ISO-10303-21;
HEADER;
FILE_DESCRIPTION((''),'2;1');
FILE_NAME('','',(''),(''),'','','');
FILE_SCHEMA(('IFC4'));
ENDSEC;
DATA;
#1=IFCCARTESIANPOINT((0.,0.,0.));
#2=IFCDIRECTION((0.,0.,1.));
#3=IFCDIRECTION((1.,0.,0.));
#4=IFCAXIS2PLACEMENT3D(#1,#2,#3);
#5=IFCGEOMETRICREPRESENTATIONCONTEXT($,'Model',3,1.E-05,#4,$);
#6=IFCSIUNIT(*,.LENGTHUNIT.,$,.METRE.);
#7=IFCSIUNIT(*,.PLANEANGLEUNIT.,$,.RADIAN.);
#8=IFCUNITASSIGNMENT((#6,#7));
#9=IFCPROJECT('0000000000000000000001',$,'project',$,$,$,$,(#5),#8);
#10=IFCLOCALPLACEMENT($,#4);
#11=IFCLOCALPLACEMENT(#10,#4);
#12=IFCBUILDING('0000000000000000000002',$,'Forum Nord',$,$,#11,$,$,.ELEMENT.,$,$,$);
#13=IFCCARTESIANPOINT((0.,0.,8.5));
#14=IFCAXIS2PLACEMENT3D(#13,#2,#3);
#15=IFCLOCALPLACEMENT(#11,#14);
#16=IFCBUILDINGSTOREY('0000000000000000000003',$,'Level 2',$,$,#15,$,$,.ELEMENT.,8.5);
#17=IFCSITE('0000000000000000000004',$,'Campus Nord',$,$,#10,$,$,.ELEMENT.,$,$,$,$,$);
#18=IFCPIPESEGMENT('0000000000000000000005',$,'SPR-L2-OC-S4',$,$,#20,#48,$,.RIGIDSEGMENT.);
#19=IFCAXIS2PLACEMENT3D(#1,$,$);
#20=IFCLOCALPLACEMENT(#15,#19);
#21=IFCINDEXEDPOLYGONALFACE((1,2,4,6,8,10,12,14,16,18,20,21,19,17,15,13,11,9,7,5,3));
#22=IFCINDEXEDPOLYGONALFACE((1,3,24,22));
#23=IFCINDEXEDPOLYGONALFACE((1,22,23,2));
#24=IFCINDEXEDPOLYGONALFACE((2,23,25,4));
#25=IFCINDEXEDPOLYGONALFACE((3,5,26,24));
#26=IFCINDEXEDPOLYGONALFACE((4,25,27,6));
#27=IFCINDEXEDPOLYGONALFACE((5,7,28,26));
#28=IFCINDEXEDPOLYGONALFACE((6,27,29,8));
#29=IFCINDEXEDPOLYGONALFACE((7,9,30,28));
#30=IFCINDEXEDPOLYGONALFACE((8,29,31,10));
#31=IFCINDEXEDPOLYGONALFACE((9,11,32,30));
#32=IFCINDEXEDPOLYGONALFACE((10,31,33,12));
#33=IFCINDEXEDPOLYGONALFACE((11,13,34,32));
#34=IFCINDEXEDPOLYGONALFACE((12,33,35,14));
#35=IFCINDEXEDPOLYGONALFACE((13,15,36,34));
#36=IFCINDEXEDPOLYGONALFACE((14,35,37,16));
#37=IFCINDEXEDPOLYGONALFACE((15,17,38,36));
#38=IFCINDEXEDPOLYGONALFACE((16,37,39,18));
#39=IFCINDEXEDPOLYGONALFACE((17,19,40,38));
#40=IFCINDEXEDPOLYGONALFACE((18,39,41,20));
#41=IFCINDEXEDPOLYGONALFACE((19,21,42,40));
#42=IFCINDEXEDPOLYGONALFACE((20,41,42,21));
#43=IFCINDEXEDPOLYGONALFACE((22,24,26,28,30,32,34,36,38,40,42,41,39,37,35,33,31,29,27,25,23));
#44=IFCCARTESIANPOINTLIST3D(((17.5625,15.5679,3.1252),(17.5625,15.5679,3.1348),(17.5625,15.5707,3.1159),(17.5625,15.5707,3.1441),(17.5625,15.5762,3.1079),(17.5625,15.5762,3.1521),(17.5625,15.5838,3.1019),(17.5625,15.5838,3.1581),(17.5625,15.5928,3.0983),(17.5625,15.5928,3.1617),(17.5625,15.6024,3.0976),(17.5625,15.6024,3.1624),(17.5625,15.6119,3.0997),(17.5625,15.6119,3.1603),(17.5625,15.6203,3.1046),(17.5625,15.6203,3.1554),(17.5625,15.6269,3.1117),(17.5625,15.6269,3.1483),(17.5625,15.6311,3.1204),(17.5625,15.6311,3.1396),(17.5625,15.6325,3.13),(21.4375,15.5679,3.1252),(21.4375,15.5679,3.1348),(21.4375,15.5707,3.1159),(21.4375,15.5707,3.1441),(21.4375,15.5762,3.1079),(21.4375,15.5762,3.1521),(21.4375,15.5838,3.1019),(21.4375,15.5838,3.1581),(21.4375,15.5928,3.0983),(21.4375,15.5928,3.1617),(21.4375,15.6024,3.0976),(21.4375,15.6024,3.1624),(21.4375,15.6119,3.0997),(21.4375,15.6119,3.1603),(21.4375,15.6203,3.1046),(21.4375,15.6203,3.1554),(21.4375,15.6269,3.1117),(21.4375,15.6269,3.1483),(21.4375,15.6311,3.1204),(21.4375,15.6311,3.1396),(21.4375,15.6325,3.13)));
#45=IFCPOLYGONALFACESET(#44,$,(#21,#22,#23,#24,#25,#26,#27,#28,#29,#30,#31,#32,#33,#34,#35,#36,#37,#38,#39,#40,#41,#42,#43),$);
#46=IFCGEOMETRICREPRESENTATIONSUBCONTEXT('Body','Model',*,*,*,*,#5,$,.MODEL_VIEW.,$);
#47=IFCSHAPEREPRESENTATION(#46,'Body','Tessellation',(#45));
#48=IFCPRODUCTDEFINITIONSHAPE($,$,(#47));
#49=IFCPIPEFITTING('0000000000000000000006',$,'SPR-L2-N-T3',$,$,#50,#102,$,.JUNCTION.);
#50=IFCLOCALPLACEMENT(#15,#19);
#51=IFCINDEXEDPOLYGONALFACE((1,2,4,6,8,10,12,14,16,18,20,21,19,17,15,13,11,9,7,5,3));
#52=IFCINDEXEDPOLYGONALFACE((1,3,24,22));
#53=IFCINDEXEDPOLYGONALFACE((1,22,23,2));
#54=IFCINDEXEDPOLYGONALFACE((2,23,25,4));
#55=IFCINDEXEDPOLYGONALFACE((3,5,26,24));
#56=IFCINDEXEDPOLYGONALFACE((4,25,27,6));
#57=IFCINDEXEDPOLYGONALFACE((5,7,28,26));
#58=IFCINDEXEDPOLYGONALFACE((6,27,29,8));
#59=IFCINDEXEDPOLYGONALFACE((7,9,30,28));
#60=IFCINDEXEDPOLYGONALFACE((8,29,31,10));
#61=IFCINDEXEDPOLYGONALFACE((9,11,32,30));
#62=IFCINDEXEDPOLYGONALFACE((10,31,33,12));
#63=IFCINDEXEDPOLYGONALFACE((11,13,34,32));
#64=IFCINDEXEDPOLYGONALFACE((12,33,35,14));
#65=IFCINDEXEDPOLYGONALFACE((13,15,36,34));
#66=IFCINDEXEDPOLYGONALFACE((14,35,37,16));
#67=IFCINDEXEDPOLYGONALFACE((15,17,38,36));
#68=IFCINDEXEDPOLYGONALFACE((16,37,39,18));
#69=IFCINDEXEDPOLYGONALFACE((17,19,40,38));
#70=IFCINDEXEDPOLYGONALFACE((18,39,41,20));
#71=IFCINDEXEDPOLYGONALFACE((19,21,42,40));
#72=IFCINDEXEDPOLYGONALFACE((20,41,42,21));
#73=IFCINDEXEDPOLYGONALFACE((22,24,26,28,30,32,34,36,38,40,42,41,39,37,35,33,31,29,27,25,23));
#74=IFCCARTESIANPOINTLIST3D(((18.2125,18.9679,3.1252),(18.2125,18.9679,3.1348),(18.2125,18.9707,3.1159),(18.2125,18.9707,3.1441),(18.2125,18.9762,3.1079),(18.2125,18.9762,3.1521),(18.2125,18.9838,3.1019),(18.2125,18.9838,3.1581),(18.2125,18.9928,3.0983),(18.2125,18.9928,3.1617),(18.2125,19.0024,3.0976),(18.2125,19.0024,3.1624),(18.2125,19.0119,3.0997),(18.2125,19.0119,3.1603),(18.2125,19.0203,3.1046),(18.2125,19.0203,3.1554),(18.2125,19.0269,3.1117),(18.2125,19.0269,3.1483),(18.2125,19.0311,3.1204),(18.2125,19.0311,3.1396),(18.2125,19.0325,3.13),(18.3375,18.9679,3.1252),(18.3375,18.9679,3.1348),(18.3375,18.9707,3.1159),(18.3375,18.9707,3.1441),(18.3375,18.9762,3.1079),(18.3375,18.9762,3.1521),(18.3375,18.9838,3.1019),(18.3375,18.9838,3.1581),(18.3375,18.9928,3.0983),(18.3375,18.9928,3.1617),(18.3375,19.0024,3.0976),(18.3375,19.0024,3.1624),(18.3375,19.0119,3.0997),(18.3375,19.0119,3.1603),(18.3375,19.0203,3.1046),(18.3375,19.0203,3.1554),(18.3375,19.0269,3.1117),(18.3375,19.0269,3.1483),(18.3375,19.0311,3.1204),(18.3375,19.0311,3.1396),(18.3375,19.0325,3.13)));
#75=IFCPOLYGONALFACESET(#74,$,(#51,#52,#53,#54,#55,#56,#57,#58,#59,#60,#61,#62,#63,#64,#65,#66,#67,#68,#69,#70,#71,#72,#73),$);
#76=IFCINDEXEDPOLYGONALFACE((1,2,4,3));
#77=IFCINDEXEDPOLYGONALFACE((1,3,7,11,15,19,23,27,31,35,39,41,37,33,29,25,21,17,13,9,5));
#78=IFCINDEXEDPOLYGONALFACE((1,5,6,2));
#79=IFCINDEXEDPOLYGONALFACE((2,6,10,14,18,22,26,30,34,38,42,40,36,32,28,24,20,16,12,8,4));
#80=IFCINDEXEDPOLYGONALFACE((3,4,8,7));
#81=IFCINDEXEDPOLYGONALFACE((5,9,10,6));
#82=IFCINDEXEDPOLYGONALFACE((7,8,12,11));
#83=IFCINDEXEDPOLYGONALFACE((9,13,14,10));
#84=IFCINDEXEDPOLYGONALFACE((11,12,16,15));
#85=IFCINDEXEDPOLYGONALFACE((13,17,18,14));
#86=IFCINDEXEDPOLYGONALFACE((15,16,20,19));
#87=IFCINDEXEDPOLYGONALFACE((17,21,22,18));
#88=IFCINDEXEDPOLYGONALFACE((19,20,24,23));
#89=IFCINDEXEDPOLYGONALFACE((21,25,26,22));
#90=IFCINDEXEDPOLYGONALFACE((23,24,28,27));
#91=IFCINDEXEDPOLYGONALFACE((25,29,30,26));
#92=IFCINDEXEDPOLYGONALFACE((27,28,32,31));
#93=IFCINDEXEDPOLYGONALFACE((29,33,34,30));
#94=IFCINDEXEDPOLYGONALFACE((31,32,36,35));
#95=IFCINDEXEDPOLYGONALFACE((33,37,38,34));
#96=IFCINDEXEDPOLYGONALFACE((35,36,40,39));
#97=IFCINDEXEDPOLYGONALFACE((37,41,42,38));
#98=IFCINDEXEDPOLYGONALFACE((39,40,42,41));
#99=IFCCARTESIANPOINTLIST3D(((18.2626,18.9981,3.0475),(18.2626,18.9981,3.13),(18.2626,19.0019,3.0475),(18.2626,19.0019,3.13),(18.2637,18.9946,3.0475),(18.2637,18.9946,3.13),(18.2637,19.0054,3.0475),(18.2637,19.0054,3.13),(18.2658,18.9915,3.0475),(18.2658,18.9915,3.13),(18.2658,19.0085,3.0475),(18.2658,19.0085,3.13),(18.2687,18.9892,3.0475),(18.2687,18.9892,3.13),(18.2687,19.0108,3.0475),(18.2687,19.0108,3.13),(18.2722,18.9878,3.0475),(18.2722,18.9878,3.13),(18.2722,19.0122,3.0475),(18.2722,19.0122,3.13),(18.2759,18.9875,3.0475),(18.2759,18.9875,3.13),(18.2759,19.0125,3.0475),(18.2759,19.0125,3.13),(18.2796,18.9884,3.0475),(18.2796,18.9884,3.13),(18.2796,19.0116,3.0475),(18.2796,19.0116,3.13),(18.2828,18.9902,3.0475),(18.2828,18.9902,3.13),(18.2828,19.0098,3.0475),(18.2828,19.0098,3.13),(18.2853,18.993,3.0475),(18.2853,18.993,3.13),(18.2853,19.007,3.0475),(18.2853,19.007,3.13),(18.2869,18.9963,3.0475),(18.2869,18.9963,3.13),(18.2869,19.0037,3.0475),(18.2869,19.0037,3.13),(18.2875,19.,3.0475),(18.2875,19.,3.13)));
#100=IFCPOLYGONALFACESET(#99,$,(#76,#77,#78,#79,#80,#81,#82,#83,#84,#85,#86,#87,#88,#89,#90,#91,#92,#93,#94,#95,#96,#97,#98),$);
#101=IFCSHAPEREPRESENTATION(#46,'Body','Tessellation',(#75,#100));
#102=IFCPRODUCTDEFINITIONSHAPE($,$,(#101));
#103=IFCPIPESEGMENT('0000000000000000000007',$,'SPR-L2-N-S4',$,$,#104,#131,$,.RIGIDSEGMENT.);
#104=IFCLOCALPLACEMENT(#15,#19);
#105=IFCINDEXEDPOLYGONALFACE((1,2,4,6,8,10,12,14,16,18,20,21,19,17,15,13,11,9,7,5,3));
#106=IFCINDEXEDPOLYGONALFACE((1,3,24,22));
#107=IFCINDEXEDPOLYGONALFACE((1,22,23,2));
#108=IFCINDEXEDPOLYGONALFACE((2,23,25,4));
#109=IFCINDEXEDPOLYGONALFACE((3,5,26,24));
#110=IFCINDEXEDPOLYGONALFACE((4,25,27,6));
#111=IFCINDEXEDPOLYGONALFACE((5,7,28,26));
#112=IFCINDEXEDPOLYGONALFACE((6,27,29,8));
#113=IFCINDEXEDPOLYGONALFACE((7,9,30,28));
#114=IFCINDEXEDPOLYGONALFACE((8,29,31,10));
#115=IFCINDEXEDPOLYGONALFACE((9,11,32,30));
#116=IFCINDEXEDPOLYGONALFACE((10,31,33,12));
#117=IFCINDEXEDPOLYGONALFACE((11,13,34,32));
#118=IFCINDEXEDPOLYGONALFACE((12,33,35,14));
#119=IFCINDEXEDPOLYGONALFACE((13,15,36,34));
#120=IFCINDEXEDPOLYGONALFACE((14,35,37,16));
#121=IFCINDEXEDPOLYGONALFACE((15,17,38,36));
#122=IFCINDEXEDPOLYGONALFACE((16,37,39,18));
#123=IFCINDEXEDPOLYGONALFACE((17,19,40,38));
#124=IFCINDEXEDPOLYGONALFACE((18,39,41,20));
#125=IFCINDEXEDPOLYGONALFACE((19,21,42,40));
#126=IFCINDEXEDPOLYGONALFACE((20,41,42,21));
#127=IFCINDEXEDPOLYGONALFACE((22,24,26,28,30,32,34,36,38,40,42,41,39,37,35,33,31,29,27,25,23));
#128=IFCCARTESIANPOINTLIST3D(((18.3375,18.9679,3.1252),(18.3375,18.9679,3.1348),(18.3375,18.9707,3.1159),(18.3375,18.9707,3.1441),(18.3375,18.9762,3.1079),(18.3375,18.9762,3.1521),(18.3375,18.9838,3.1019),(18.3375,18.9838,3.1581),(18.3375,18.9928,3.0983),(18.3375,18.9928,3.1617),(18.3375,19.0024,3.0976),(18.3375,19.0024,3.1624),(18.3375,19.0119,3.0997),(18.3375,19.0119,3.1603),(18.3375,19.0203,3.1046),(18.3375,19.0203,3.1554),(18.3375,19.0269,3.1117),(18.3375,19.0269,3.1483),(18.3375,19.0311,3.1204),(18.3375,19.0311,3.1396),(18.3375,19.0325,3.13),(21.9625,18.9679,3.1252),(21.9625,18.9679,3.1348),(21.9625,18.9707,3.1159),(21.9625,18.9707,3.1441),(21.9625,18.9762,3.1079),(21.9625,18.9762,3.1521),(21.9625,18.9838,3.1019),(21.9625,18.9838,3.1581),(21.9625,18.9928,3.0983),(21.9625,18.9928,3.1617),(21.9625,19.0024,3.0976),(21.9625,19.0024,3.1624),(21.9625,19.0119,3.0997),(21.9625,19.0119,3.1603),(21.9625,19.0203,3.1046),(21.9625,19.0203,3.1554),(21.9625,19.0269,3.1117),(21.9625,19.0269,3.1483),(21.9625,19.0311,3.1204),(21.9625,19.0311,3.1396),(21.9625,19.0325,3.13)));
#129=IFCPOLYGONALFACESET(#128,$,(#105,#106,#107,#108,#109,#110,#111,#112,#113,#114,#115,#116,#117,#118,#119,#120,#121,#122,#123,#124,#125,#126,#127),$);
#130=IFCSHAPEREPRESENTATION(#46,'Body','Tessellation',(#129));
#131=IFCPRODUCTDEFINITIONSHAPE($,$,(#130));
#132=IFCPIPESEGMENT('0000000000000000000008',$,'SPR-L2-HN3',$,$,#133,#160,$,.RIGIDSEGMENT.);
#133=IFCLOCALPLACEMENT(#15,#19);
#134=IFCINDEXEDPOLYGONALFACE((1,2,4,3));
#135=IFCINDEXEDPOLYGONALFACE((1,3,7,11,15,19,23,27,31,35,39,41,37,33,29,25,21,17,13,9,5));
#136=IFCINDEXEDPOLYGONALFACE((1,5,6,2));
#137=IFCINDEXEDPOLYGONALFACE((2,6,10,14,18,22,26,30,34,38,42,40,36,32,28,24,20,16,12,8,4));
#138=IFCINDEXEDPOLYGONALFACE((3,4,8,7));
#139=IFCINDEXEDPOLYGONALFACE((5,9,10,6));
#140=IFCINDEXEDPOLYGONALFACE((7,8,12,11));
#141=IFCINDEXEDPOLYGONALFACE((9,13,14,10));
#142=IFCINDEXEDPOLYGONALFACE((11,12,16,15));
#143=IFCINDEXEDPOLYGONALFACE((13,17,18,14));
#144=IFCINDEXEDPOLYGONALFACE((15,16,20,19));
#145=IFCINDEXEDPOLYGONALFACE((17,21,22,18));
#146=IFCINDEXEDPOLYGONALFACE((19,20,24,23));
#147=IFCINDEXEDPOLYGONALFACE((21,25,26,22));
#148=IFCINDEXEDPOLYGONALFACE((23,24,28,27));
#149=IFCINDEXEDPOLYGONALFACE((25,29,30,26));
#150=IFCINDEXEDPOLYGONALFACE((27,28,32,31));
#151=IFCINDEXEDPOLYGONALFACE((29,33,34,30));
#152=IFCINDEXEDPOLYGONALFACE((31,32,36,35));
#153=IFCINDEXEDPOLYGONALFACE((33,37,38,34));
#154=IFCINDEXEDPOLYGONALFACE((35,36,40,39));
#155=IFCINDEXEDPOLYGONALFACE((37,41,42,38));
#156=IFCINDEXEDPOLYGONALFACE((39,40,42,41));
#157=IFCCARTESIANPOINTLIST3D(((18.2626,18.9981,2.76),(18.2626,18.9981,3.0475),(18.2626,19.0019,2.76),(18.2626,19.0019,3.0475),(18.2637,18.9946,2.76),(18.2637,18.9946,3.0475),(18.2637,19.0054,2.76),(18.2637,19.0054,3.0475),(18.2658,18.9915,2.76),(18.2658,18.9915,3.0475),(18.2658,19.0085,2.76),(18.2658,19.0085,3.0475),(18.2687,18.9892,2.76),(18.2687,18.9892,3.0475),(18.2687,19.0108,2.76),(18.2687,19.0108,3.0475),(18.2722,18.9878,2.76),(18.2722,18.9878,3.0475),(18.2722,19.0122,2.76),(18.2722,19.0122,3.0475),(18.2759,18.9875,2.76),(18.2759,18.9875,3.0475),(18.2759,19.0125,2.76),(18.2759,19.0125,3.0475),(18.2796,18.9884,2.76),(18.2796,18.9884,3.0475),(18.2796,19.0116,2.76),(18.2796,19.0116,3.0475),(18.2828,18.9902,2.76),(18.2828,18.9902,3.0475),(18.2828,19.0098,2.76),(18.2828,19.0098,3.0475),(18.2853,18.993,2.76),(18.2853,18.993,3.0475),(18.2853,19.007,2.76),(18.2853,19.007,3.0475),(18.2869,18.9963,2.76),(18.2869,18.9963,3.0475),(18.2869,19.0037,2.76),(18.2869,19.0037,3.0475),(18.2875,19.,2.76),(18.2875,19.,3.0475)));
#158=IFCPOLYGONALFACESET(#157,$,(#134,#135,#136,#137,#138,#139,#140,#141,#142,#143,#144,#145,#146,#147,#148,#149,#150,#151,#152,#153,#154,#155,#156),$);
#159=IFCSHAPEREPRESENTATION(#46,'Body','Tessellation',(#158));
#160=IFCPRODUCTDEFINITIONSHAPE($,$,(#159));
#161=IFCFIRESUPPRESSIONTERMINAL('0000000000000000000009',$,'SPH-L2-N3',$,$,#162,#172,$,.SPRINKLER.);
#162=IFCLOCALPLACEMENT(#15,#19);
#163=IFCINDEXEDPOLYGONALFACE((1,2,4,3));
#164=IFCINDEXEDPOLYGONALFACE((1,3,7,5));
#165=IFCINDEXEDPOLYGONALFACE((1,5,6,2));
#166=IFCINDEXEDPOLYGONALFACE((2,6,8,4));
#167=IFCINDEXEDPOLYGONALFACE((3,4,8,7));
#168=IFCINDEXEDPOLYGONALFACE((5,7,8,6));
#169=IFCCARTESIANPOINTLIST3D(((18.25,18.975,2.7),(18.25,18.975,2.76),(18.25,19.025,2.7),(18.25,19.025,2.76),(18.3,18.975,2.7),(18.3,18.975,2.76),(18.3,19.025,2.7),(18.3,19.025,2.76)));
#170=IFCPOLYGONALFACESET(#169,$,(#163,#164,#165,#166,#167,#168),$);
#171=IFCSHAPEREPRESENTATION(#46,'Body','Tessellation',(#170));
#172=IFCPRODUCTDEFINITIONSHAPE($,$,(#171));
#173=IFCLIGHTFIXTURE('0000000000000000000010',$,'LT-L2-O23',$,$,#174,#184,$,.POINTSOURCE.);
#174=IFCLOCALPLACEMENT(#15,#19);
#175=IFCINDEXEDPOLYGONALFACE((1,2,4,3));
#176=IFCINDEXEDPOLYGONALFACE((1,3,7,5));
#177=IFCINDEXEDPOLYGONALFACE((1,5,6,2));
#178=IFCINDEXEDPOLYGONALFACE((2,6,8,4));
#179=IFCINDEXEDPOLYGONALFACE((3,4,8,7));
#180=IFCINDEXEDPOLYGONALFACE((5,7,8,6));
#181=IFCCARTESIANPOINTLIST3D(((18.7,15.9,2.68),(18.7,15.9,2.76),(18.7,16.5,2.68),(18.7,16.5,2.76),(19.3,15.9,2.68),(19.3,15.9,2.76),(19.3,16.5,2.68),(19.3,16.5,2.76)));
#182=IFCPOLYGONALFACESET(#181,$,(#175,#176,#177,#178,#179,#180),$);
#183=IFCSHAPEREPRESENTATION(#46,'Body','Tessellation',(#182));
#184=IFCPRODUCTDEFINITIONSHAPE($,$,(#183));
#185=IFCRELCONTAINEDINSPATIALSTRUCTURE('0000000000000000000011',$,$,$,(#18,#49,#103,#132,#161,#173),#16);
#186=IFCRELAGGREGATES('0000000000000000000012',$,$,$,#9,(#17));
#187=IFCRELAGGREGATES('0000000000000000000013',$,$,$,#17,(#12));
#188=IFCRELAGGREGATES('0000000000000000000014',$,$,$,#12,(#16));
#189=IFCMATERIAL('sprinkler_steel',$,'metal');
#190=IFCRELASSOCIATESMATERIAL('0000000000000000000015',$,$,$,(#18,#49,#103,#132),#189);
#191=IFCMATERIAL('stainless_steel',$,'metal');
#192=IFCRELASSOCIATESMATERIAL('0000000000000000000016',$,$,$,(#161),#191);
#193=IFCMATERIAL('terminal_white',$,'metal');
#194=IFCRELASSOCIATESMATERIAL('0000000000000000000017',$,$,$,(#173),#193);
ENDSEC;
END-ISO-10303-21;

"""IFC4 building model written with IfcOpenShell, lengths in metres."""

from ifc_helpers import new_model, si_unit, frame, origin_with_axes, origin_2d_with_axis, place, context, subcontext, project, spatial, rectangle, circle, extrude, material, element, save


model = new_model("IFC4")

# Units and contexts
model_context = context("Model", 3, precision=1e-05, world=origin_with_axes())
body_context = subcontext(model_context, "Body", "Model", "MODEL_VIEW")
ifc_project = project(units=[si_unit("LENGTHUNIT", "METRE"), si_unit("PLANEANGLEUNIT", "RADIAN")], contexts=[model_context])

# Site, building, storey
site_placement = place(None, origin_with_axes())
site = spatial("IfcSite", under=ifc_project, at=site_placement, Name="Campus Nord", CompositionType="ELEMENT")
building_placement = place(site_placement, origin_with_axes())
building = spatial("IfcBuilding", under=site, at=building_placement, Name="Forum Nord", CompositionType="ELEMENT")
storey_placement = place(building_placement, frame((0.0, 0.0, 8.5), z_axis=(0.0, 0.0, 1.0), x_axis=(1.0, 0.0, 0.0)))
storey = spatial("IfcBuildingStorey", under=building, at=storey_placement, Name="Level 2", CompositionType="ELEMENT", Elevation=8.5)

# Shared definitions
ifc_material_1 = material(Name="terminal_white", Category="metal")

# Pipe segment
ifc_material_2 = material(Name="sprinkler_steel", Category="metal")
pipe_segment_1_placement = place(storey_placement, frame((17.5625, 15.6, 3.13), z_axis=(1.0, 0.0, 0.0), x_axis=(0.0, 1.0, 0.0)))
element("IfcPipeSegment", 1, at=pipe_segment_1_placement, inside=storey, material=ifc_material_2, Name="SPR-L2-OC-S4", PredefinedType="RIGIDSEGMENT", context=body_context, shape_type="SweptSolid", body=[
    extrude(circle(Radius=0.0325, at=origin_2d_with_axis()), origin_with_axes(), (0.0, 0.0, 1.0), 3.875),
])

# Pipe fitting
pipe_fitting_placement = place(storey_placement, frame((18.2125, 19.0, 3.13), z_axis=(1.0, 0.0, 0.0), x_axis=(0.0, 1.0, 0.0)))
element("IfcPipeFitting", 2, at=pipe_fitting_placement, inside=storey, material=ifc_material_2, Name="SPR-L2-N-T3", PredefinedType="JUNCTION", context=body_context, shape_type="SweptSolid", body=[
    extrude(circle(Radius=0.0325, at=origin_2d_with_axis()), origin_with_axes(), (0.0, 0.0, 1.0), 0.125),
    extrude(circle(Radius=0.0125, at=origin_2d_with_axis()), frame((0.0, 0.0, 0.0625), z_axis=(0.0, -1.0, 0.0), x_axis=(0.0, 0.0, 1.0)), (0.0, 0.0, 1.0), 0.0825),
])

# Pipe segments
pipe_segment_2_placement = place(storey_placement, frame((18.3375, 19.0, 3.13), z_axis=(1.0, 0.0, 0.0), x_axis=(0.0, 1.0, 0.0)))
element("IfcPipeSegment", 3, at=pipe_segment_2_placement, inside=storey, material=ifc_material_2, Name="SPR-L2-N-S4", PredefinedType="RIGIDSEGMENT", context=body_context, shape_type="SweptSolid", body=[
    extrude(circle(Radius=0.0325, at=origin_2d_with_axis()), origin_with_axes(), (0.0, 0.0, 1.0), 3.625),
])
pipe_segment_3_placement = place(storey_placement, frame((18.275, 19.0, 3.0475), z_axis=(0.0, 0.0, -1.0), x_axis=(1.0, 0.0, 0.0)))
element("IfcPipeSegment", 4, at=pipe_segment_3_placement, inside=storey, material=ifc_material_2, Name="SPR-L2-HN3", PredefinedType="RIGIDSEGMENT", context=body_context, shape_type="SweptSolid", body=[
    extrude(circle(Radius=0.0125, at=origin_2d_with_axis()), origin_with_axes(), (0.0, 0.0, 1.0), 0.2875),
])

# Fire suppression terminal
ifc_material_3 = material(Name="stainless_steel", Category="metal")
fire_suppression_terminal_placement = place(storey_placement, frame((18.275, 19.0, 2.7), z_axis=(0.0, 0.0, 1.0), x_axis=(1.0, 0.0, 0.0)))
element("IfcFireSuppressionTerminal", 5, at=fire_suppression_terminal_placement, inside=storey, material=ifc_material_3, Name="SPH-L2-N3", PredefinedType="SPRINKLER", context=body_context, shape_type="SweptSolid", body=[
    extrude(rectangle(XDim=0.05, YDim=0.05, at=origin_2d_with_axis()), origin_with_axes(), (0.0, 0.0, 1.0), 0.06),
])

# Light fixture
light_fixture_placement = place(storey_placement, frame((19.0, 16.2, 2.68), z_axis=(0.0, 0.0, 1.0), x_axis=(1.0, 0.0, 0.0)))
element("IfcLightFixture", 6, at=light_fixture_placement, inside=storey, material=ifc_material_1, Name="LT-L2-O23", PredefinedType="POINTSOURCE", context=body_context, shape_type="SweptSolid", body=[
    extrude(rectangle(XDim=0.6, YDim=0.6, at=origin_2d_with_axis()), origin_with_axes(), (0.0, 0.0, 1.0), 0.08),
])

save(model, "model.ifc")
